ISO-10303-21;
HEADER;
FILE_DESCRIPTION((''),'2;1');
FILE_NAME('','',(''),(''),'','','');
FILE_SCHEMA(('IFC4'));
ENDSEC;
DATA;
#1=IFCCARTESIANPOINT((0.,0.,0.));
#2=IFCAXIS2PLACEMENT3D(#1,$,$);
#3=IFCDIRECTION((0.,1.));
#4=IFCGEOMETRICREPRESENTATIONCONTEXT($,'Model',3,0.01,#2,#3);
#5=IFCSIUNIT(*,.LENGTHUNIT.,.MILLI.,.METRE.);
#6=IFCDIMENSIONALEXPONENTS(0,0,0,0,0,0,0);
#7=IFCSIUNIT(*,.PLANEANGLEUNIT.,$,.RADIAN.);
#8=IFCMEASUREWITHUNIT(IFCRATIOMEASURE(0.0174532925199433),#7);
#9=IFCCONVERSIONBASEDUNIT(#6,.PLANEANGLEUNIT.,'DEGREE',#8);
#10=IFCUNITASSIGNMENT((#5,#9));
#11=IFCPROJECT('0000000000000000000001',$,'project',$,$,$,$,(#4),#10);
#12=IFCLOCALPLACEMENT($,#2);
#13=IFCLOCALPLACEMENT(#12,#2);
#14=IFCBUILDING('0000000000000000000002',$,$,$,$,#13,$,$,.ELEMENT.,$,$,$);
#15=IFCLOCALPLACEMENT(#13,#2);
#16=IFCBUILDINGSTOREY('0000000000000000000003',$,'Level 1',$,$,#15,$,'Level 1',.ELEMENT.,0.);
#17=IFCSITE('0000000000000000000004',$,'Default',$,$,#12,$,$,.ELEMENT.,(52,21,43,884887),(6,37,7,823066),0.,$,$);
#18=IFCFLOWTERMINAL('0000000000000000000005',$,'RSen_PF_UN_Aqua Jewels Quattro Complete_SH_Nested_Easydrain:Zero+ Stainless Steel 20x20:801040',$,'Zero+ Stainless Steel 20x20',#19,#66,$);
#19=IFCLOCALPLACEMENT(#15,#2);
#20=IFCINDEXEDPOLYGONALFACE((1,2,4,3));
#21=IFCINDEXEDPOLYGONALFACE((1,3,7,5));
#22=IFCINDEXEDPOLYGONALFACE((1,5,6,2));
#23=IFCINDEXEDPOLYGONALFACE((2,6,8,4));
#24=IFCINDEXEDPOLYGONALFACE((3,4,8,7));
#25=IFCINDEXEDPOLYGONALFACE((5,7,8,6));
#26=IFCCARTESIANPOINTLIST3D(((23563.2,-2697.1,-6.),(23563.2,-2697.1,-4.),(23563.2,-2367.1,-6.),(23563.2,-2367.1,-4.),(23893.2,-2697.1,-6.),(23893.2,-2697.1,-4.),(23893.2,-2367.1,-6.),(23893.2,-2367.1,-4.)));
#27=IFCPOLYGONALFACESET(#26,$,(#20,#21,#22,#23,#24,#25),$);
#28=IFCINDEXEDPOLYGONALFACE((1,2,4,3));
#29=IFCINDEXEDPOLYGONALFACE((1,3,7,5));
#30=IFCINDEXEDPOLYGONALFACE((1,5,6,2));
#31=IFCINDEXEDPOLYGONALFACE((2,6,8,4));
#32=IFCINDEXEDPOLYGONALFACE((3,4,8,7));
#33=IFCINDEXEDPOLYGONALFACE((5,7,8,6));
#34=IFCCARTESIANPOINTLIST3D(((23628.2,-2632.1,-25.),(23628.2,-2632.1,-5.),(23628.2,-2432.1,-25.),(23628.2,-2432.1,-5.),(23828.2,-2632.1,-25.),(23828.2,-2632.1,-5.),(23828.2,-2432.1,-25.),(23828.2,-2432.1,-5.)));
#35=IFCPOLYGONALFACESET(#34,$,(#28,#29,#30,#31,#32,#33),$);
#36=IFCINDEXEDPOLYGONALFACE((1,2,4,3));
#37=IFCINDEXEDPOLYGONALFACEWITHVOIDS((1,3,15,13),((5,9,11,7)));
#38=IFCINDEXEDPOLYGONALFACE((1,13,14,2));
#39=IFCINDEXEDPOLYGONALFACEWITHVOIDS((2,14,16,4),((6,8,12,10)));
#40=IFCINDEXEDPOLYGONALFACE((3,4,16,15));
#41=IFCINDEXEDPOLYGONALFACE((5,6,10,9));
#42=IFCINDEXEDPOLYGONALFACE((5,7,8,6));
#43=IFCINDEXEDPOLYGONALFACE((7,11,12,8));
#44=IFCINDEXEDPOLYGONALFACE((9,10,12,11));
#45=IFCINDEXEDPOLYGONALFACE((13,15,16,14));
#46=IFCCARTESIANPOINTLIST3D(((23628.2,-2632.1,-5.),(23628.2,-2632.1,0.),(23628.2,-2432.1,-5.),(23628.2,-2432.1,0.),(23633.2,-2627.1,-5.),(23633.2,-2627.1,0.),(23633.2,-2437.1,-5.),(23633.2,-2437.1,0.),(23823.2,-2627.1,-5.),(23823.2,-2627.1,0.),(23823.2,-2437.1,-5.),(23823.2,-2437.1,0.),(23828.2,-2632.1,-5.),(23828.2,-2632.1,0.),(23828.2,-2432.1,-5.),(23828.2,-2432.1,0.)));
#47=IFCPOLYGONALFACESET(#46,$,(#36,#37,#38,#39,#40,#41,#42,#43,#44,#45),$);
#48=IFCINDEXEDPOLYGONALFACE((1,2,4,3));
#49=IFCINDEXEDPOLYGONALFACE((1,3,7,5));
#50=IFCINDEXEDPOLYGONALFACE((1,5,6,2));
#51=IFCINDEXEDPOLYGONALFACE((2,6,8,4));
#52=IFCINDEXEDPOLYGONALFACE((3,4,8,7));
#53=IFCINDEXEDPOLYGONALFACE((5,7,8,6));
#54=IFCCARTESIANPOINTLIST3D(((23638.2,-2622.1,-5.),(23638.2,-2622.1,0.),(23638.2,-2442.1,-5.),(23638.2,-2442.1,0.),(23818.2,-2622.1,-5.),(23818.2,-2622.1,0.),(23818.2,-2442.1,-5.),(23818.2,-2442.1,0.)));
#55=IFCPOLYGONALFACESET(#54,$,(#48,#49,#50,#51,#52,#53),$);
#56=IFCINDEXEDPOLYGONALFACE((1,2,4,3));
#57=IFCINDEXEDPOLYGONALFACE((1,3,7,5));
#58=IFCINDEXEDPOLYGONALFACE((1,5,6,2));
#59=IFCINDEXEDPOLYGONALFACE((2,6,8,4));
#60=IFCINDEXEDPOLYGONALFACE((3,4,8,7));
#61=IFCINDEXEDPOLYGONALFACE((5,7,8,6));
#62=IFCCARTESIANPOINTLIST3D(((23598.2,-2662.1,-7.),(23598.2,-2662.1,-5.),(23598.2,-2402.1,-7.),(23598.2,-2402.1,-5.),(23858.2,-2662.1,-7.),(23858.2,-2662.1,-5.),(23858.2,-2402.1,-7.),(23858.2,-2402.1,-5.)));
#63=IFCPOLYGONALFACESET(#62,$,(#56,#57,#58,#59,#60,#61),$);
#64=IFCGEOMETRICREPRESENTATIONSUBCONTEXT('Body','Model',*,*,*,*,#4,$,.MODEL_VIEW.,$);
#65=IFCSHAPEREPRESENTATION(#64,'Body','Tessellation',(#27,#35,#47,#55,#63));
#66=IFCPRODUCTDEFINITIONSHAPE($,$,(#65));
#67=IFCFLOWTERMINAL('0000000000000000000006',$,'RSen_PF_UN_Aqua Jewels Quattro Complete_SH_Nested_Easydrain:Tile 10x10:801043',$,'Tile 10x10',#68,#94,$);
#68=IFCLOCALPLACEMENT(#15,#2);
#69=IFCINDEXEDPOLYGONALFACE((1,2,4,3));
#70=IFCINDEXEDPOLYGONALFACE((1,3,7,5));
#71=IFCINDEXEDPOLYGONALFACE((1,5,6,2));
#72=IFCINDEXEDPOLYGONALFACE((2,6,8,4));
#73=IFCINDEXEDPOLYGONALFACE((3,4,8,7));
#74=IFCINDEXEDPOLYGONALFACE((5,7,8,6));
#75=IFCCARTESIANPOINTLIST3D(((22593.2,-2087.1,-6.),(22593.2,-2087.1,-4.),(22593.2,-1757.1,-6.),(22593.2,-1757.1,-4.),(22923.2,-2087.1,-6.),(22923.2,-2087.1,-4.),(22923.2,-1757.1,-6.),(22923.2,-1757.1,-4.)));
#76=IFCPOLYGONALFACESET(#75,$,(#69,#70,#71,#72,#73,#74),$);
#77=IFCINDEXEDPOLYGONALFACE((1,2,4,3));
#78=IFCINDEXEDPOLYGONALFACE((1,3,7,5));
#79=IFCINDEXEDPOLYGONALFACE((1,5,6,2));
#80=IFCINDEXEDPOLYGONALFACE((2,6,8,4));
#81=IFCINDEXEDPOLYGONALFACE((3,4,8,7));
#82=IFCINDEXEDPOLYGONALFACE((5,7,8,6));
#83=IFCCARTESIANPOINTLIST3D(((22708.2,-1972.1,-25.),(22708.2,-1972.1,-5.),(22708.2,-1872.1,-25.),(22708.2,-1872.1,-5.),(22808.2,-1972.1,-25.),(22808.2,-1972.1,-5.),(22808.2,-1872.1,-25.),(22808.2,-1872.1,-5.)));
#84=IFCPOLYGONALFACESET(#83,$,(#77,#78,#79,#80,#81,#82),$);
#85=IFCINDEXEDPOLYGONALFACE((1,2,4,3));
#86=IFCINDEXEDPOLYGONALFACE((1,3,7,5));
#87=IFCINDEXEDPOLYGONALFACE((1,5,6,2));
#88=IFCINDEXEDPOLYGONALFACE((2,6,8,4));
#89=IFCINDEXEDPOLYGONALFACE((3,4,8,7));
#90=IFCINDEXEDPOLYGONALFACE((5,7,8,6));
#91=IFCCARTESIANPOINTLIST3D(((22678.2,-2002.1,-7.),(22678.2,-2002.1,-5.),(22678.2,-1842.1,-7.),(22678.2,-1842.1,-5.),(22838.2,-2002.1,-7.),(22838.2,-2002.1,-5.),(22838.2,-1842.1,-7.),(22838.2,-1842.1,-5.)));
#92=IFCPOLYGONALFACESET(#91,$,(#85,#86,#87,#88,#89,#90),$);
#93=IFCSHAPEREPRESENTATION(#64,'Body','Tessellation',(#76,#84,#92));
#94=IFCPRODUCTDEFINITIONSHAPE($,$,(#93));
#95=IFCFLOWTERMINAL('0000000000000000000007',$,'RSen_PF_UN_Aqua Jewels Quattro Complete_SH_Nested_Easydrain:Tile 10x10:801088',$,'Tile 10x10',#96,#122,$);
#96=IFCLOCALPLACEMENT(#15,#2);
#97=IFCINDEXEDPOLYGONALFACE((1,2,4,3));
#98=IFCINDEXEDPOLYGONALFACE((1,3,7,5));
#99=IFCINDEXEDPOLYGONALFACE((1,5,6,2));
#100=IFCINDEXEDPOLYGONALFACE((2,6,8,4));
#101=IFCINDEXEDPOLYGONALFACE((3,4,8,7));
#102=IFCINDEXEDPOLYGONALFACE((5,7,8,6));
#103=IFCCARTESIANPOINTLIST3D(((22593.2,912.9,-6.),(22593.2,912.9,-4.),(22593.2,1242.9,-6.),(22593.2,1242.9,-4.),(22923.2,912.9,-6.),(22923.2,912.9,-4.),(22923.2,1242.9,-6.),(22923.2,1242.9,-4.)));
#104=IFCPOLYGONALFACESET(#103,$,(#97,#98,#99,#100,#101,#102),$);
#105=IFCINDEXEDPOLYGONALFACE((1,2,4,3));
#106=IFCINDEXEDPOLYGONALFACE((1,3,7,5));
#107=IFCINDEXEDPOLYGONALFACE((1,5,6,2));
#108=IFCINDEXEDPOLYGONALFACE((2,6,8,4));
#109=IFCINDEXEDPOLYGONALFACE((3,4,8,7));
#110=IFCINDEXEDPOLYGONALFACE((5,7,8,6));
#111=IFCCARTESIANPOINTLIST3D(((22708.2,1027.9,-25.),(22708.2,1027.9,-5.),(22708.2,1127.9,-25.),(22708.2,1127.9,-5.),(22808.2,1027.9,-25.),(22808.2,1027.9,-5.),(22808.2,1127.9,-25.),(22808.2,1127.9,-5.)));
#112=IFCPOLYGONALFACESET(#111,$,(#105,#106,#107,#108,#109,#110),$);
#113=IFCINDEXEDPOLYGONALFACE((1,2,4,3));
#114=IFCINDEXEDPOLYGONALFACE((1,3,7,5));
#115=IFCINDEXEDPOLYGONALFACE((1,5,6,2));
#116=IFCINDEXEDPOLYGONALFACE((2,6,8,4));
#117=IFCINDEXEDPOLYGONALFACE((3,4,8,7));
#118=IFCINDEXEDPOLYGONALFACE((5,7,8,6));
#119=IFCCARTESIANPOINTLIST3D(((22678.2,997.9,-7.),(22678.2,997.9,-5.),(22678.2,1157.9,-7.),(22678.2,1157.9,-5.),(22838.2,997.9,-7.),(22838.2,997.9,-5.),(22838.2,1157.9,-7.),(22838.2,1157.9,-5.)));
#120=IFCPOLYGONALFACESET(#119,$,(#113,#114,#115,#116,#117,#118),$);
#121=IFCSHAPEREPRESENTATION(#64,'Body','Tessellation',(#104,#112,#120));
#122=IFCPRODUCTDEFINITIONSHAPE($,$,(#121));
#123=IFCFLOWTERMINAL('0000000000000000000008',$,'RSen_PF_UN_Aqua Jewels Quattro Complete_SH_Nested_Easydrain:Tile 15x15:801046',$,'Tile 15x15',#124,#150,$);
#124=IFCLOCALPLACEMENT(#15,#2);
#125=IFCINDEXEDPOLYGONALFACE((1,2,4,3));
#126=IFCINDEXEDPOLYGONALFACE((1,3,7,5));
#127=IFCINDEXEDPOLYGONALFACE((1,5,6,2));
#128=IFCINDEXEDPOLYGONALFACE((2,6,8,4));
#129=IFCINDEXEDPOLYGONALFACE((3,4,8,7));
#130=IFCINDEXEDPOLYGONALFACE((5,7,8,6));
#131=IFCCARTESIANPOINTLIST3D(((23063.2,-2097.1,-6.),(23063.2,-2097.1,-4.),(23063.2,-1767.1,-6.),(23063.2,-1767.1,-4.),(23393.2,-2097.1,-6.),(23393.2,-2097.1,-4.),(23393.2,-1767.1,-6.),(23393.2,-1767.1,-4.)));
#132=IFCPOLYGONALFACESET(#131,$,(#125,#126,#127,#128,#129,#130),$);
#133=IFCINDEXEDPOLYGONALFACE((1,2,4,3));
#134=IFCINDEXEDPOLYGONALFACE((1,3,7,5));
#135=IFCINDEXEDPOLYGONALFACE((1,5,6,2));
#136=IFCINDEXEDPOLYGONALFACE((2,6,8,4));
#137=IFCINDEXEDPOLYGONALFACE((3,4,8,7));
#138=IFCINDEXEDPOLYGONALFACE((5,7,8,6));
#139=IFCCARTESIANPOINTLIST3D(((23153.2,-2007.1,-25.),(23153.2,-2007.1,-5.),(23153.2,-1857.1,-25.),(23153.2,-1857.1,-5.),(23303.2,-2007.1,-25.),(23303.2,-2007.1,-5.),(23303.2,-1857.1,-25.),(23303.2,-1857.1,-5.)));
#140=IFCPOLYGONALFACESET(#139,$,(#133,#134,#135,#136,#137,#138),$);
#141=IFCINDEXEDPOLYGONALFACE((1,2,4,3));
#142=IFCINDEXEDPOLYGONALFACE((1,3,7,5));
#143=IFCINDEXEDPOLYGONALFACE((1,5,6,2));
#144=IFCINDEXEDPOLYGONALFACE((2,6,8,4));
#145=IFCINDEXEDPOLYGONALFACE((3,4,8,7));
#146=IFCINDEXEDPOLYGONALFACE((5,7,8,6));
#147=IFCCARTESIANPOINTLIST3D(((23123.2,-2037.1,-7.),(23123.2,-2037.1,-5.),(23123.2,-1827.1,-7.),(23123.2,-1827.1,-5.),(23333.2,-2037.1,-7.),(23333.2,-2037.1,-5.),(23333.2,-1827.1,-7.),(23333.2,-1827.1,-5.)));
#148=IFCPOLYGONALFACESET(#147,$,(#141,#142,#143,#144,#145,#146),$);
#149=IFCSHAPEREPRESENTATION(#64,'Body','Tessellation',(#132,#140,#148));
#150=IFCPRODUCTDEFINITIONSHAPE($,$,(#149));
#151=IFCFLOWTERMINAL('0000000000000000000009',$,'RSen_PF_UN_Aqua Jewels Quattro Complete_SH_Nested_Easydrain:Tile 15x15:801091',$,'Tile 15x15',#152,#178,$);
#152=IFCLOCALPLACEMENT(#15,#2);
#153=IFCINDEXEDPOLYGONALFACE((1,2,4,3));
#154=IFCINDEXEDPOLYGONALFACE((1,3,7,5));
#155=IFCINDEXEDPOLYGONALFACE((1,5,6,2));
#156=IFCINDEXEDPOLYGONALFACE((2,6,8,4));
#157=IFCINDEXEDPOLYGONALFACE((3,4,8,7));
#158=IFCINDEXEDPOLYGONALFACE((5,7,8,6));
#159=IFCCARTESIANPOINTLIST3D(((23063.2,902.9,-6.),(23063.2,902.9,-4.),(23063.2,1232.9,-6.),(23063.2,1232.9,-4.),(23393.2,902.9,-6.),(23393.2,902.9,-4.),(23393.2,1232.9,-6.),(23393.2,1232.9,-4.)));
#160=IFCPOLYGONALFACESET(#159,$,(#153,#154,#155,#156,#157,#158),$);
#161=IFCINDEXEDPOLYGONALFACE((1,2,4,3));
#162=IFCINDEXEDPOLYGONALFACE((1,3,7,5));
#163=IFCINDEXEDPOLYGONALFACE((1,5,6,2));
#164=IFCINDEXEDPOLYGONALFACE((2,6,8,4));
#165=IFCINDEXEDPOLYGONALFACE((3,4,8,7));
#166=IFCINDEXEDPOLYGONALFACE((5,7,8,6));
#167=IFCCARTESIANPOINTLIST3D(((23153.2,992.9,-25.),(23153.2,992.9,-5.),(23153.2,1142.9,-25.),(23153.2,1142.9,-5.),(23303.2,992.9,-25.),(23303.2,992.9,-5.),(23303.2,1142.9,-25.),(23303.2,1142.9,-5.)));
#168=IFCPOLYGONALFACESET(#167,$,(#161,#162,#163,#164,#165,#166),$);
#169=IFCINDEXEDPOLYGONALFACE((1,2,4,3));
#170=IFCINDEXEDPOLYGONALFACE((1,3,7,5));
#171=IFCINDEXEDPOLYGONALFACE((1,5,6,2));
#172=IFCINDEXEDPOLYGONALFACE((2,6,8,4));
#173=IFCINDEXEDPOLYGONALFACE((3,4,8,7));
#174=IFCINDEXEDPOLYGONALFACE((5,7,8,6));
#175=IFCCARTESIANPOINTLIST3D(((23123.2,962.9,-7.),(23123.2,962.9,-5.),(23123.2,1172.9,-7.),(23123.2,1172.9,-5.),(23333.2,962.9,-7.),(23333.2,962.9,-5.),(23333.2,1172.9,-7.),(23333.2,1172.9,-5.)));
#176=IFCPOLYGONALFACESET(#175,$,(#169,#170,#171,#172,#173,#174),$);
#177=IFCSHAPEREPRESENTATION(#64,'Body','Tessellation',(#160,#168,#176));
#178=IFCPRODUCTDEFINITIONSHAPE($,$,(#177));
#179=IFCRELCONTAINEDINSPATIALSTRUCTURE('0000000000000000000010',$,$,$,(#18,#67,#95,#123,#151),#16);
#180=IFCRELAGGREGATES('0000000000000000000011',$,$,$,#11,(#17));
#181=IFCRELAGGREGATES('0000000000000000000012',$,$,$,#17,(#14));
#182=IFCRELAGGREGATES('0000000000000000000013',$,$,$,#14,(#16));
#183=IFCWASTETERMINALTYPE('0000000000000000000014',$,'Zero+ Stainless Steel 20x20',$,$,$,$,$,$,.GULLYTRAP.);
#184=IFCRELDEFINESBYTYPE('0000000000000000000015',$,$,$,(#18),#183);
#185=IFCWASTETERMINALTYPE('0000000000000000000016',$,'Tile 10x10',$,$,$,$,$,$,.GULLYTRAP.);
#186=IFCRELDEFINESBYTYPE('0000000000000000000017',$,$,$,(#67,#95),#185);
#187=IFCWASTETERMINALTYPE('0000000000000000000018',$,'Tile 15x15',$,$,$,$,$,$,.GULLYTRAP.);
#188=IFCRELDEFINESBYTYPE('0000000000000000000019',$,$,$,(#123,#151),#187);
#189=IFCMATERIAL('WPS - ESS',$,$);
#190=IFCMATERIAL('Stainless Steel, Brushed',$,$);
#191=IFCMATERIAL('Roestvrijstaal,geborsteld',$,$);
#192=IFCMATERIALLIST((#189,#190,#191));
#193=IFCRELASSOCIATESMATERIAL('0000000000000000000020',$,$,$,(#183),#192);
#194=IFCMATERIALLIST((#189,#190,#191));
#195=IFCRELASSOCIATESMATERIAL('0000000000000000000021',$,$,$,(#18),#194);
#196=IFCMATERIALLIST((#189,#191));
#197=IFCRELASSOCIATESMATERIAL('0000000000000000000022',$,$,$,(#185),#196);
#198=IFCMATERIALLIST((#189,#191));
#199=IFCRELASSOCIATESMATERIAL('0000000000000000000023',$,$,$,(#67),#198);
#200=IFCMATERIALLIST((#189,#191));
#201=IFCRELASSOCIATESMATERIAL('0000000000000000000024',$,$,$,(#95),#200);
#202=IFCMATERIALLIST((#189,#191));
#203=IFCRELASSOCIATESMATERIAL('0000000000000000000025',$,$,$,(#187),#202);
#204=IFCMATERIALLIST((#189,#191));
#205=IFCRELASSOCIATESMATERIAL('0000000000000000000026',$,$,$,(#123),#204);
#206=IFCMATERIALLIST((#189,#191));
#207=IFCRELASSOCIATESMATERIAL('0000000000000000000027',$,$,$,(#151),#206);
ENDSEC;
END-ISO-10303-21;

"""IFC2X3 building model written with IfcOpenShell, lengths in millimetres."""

from ifc_helpers import new_model, entity, si_unit, converted_unit, direction, frame, frame_2d, origin, origin_2d_with_axis, place, context, subcontext, project, spatial, polyline, rectangle, outline, extrude, source, transform, mapped, material, material_list, type_object, type_shapes, element, save


model = new_model("IFC2X3")

# Units and contexts
model_context = context("Model", 3, precision=0.01, world=origin(), true_north=direction((0.0, 1.0)))
body_context = subcontext(model_context, "Body", "Model", "MODEL_VIEW")
ifc_project = project(units=[si_unit("LENGTHUNIT", "METRE", prefix="MILLI"), converted_unit("PLANEANGLEUNIT", "DEGREE", entity("IfcRatioMeasure", 0.0174532925199433), si_unit("PLANEANGLEUNIT", "RADIAN"), dimensions=[0, 0, 0, 0, 0, 0, 0])], contexts=[model_context])

# Site, building, storey
site_placement = place(None, origin())
site = spatial("IfcSite", under=ifc_project, at=site_placement, Name="Default", CompositionType="ELEMENT", RefLatitude=(52, 21, 43, 884887), RefLongitude=(6, 37, 7, 823066), RefElevation=0.0)
building_placement = place(site_placement, origin())
building = spatial("IfcBuilding", under=site, at=building_placement, CompositionType="ELEMENT")
storey_placement = place(building_placement, origin())
storey = spatial("IfcBuildingStorey", under=building, at=storey_placement, Name="Level 1", LongName="Level 1", CompositionType="ELEMENT", Elevation=0.0)

# Flow terminals
ifc_material_1 = material(Name="WPS - ESS")
ifc_material_2 = material(Name="Stainless Steel, Brushed")
ifc_material_3 = material(Name="Roestvrijstaal,geborsteld")
ifc_material_list_1 = material_list([ifc_material_1, ifc_material_2, ifc_material_3])
ifc_material_list_2 = material_list([ifc_material_1, ifc_material_2, ifc_material_3])
waste_terminal_type_1 = type_object("IfcWasteTerminalType", Name="Zero+ Stainless Steel 20x20", PredefinedType="GULLYTRAP", material=ifc_material_list_2)
shared_shape_1 = source(origin(), body_context, "Body", "SweptSolid", [
    extrude(rectangle(XDim=330.0, YDim=330.0, at=origin_2d_with_axis()), frame((5.0, -10.0, -6.0), z_axis=(0.0, 0.0, 1.0), x_axis=(-1.0, 0.0, 0.0)), (0.0, 0.0, 1.0), 2.0),
    extrude(rectangle(XDim=200.0, YDim=200.0, at=origin_2d_with_axis()), frame((5.0, -10.0, -25.0), z_axis=(0.0, 0.0, 1.0), x_axis=(-1.0, 0.0, 0.0)), (0.0, 0.0, 1.0), 20.0),
    extrude(outline(polyline([(-100.0, -100.0), (100.0, -100.0), (100.0, 100.0), (-100.0, 100.0), (-100.0, -100.0)]), holes=[polyline([(-95.0, -95.0), (-95.0, 95.0), (95.0, 95.0), (95.0, -95.0), (-95.0, -95.0)])]), frame((5.0, -10.0, -5.0), z_axis=(0.0, 0.0, 1.0), x_axis=(-1.0, 0.0, 0.0)), (0.0, 0.0, 1.0), 5.0),
    extrude(rectangle(XDim=180.0, YDim=180.0, at=frame_2d((0.0, 0.0), x_axis=(1.0, 0.0))), frame((5.0, -10.0, -5.0), z_axis=(0.0, 0.0, 1.0), x_axis=(-1.0, 0.0, 0.0)), (0.0, 0.0, 1.0), 5.0),
    extrude(rectangle(XDim=260.0, YDim=260.0, at=origin_2d_with_axis()), frame((5.0, -10.0, -7.0), z_axis=(0.0, 0.0, 1.0), x_axis=(-1.0, 0.0, 0.0)), (0.0, 0.0, 1.0), 2.0),
])
type_shapes(waste_terminal_type_1, [shared_shape_1])
flow_terminal_1_placement = place(storey_placement, frame((23723.2, -2522.1, 0.0)))
element("IfcFlowTerminal", 1, at=flow_terminal_1_placement, inside=storey, type_object=waste_terminal_type_1, material=ifc_material_list_1, Name="RSen_PF_UN_Aqua Jewels Quattro Complete_SH_Nested_Easydrain:Zero+ Stainless Steel 20x20:801040", ObjectType="Zero+ Stainless Steel 20x20", context=body_context, shape_type="MappedRepresentation", body=[
    mapped(shared_shape_1, transform((0.0, 0.0, 0.0), scale=1.0)),
])
ifc_material_list_3 = material_list([ifc_material_1, ifc_material_3])
ifc_material_list_4 = material_list([ifc_material_1, ifc_material_3])
waste_terminal_type_2 = type_object("IfcWasteTerminalType", Name="Tile 10x10", PredefinedType="GULLYTRAP", material=ifc_material_list_4)
shared_shape_2 = source(origin(), body_context, "Body", "SweptSolid", [
    extrude(rectangle(XDim=330.0, YDim=330.0, at=origin_2d_with_axis()), frame((0.0, 0.0, -6.0), z_axis=(0.0, 0.0, 1.0), x_axis=(-1.0, 0.0, 0.0)), (0.0, 0.0, 1.0), 2.0),
    extrude(rectangle(XDim=100.0, YDim=100.0, at=origin_2d_with_axis()), frame((0.0, 0.0, -25.0), z_axis=(0.0, 0.0, 1.0), x_axis=(-1.0, 0.0, 0.0)), (0.0, 0.0, 1.0), 20.0),
    extrude(rectangle(XDim=160.0, YDim=160.0, at=origin_2d_with_axis()), frame((0.0, 0.0, -7.0), z_axis=(0.0, 0.0, 1.0), x_axis=(-1.0, 0.0, 0.0)), (0.0, 0.0, 1.0), 2.0),
])
type_shapes(waste_terminal_type_2, [shared_shape_2])
flow_terminal_2_placement = place(storey_placement, frame((22758.2, -1922.1, 0.0)))
element("IfcFlowTerminal", 2, at=flow_terminal_2_placement, inside=storey, type_object=waste_terminal_type_2, material=ifc_material_list_3, Name="RSen_PF_UN_Aqua Jewels Quattro Complete_SH_Nested_Easydrain:Tile 10x10:801043", ObjectType="Tile 10x10", context=body_context, shape_type="MappedRepresentation", body=[
    mapped(shared_shape_2, transform((0.0, 0.0, 0.0), scale=1.0)),
])
ifc_material_list_5 = material_list([ifc_material_1, ifc_material_3])
flow_terminal_3_placement = place(storey_placement, frame((22758.2, 1077.9, 0.0)))
element("IfcFlowTerminal", 3, at=flow_terminal_3_placement, inside=storey, type_object=waste_terminal_type_2, material=ifc_material_list_5, Name="RSen_PF_UN_Aqua Jewels Quattro Complete_SH_Nested_Easydrain:Tile 10x10:801088", ObjectType="Tile 10x10", context=body_context, shape_type="MappedRepresentation", body=[
    mapped(shared_shape_2, transform((0.0, 0.0, 0.0), scale=1.0)),
])
ifc_material_list_6 = material_list([ifc_material_1, ifc_material_3])
ifc_material_list_7 = material_list([ifc_material_1, ifc_material_3])
waste_terminal_type_3 = type_object("IfcWasteTerminalType", Name="Tile 15x15", PredefinedType="GULLYTRAP", material=ifc_material_list_7)
shared_shape_3 = source(origin(), body_context, "Body", "SweptSolid", [
    extrude(rectangle(XDim=330.0, YDim=330.0, at=origin_2d_with_axis()), frame((5.0, -10.0, -6.0), z_axis=(0.0, 0.0, 1.0), x_axis=(-1.0, 0.0, 0.0)), (0.0, 0.0, 1.0), 2.0),
    extrude(rectangle(XDim=150.0, YDim=150.0, at=origin_2d_with_axis()), frame((5.0, -10.0, -25.0), z_axis=(0.0, 0.0, 1.0), x_axis=(-1.0, 0.0, 0.0)), (0.0, 0.0, 1.0), 20.0),
    extrude(rectangle(XDim=210.0, YDim=210.0, at=origin_2d_with_axis()), frame((5.0, -10.0, -7.0), z_axis=(0.0, 0.0, 1.0), x_axis=(-1.0, 0.0, 0.0)), (0.0, 0.0, 1.0), 2.0),
])
type_shapes(waste_terminal_type_3, [shared_shape_3])
flow_terminal_4_placement = place(storey_placement, frame((23223.2, -1922.1, 0.0)))
element("IfcFlowTerminal", 4, at=flow_terminal_4_placement, inside=storey, type_object=waste_terminal_type_3, material=ifc_material_list_6, Name="RSen_PF_UN_Aqua Jewels Quattro Complete_SH_Nested_Easydrain:Tile 15x15:801046", ObjectType="Tile 15x15", context=body_context, shape_type="MappedRepresentation", body=[
    mapped(shared_shape_3, transform((0.0, 0.0, 0.0), scale=1.0)),
])
ifc_material_list_8 = material_list([ifc_material_1, ifc_material_3])
flow_terminal_5_placement = place(storey_placement, frame((23223.2, 1077.9, 0.0)))
element("IfcFlowTerminal", 5, at=flow_terminal_5_placement, inside=storey, type_object=waste_terminal_type_3, material=ifc_material_list_8, Name="RSen_PF_UN_Aqua Jewels Quattro Complete_SH_Nested_Easydrain:Tile 15x15:801091", ObjectType="Tile 15x15", context=body_context, shape_type="MappedRepresentation", body=[
    mapped(shared_shape_3, transform((0.0, 0.0, 0.0), scale=1.0)),
])

save(model, "model.ifc")
